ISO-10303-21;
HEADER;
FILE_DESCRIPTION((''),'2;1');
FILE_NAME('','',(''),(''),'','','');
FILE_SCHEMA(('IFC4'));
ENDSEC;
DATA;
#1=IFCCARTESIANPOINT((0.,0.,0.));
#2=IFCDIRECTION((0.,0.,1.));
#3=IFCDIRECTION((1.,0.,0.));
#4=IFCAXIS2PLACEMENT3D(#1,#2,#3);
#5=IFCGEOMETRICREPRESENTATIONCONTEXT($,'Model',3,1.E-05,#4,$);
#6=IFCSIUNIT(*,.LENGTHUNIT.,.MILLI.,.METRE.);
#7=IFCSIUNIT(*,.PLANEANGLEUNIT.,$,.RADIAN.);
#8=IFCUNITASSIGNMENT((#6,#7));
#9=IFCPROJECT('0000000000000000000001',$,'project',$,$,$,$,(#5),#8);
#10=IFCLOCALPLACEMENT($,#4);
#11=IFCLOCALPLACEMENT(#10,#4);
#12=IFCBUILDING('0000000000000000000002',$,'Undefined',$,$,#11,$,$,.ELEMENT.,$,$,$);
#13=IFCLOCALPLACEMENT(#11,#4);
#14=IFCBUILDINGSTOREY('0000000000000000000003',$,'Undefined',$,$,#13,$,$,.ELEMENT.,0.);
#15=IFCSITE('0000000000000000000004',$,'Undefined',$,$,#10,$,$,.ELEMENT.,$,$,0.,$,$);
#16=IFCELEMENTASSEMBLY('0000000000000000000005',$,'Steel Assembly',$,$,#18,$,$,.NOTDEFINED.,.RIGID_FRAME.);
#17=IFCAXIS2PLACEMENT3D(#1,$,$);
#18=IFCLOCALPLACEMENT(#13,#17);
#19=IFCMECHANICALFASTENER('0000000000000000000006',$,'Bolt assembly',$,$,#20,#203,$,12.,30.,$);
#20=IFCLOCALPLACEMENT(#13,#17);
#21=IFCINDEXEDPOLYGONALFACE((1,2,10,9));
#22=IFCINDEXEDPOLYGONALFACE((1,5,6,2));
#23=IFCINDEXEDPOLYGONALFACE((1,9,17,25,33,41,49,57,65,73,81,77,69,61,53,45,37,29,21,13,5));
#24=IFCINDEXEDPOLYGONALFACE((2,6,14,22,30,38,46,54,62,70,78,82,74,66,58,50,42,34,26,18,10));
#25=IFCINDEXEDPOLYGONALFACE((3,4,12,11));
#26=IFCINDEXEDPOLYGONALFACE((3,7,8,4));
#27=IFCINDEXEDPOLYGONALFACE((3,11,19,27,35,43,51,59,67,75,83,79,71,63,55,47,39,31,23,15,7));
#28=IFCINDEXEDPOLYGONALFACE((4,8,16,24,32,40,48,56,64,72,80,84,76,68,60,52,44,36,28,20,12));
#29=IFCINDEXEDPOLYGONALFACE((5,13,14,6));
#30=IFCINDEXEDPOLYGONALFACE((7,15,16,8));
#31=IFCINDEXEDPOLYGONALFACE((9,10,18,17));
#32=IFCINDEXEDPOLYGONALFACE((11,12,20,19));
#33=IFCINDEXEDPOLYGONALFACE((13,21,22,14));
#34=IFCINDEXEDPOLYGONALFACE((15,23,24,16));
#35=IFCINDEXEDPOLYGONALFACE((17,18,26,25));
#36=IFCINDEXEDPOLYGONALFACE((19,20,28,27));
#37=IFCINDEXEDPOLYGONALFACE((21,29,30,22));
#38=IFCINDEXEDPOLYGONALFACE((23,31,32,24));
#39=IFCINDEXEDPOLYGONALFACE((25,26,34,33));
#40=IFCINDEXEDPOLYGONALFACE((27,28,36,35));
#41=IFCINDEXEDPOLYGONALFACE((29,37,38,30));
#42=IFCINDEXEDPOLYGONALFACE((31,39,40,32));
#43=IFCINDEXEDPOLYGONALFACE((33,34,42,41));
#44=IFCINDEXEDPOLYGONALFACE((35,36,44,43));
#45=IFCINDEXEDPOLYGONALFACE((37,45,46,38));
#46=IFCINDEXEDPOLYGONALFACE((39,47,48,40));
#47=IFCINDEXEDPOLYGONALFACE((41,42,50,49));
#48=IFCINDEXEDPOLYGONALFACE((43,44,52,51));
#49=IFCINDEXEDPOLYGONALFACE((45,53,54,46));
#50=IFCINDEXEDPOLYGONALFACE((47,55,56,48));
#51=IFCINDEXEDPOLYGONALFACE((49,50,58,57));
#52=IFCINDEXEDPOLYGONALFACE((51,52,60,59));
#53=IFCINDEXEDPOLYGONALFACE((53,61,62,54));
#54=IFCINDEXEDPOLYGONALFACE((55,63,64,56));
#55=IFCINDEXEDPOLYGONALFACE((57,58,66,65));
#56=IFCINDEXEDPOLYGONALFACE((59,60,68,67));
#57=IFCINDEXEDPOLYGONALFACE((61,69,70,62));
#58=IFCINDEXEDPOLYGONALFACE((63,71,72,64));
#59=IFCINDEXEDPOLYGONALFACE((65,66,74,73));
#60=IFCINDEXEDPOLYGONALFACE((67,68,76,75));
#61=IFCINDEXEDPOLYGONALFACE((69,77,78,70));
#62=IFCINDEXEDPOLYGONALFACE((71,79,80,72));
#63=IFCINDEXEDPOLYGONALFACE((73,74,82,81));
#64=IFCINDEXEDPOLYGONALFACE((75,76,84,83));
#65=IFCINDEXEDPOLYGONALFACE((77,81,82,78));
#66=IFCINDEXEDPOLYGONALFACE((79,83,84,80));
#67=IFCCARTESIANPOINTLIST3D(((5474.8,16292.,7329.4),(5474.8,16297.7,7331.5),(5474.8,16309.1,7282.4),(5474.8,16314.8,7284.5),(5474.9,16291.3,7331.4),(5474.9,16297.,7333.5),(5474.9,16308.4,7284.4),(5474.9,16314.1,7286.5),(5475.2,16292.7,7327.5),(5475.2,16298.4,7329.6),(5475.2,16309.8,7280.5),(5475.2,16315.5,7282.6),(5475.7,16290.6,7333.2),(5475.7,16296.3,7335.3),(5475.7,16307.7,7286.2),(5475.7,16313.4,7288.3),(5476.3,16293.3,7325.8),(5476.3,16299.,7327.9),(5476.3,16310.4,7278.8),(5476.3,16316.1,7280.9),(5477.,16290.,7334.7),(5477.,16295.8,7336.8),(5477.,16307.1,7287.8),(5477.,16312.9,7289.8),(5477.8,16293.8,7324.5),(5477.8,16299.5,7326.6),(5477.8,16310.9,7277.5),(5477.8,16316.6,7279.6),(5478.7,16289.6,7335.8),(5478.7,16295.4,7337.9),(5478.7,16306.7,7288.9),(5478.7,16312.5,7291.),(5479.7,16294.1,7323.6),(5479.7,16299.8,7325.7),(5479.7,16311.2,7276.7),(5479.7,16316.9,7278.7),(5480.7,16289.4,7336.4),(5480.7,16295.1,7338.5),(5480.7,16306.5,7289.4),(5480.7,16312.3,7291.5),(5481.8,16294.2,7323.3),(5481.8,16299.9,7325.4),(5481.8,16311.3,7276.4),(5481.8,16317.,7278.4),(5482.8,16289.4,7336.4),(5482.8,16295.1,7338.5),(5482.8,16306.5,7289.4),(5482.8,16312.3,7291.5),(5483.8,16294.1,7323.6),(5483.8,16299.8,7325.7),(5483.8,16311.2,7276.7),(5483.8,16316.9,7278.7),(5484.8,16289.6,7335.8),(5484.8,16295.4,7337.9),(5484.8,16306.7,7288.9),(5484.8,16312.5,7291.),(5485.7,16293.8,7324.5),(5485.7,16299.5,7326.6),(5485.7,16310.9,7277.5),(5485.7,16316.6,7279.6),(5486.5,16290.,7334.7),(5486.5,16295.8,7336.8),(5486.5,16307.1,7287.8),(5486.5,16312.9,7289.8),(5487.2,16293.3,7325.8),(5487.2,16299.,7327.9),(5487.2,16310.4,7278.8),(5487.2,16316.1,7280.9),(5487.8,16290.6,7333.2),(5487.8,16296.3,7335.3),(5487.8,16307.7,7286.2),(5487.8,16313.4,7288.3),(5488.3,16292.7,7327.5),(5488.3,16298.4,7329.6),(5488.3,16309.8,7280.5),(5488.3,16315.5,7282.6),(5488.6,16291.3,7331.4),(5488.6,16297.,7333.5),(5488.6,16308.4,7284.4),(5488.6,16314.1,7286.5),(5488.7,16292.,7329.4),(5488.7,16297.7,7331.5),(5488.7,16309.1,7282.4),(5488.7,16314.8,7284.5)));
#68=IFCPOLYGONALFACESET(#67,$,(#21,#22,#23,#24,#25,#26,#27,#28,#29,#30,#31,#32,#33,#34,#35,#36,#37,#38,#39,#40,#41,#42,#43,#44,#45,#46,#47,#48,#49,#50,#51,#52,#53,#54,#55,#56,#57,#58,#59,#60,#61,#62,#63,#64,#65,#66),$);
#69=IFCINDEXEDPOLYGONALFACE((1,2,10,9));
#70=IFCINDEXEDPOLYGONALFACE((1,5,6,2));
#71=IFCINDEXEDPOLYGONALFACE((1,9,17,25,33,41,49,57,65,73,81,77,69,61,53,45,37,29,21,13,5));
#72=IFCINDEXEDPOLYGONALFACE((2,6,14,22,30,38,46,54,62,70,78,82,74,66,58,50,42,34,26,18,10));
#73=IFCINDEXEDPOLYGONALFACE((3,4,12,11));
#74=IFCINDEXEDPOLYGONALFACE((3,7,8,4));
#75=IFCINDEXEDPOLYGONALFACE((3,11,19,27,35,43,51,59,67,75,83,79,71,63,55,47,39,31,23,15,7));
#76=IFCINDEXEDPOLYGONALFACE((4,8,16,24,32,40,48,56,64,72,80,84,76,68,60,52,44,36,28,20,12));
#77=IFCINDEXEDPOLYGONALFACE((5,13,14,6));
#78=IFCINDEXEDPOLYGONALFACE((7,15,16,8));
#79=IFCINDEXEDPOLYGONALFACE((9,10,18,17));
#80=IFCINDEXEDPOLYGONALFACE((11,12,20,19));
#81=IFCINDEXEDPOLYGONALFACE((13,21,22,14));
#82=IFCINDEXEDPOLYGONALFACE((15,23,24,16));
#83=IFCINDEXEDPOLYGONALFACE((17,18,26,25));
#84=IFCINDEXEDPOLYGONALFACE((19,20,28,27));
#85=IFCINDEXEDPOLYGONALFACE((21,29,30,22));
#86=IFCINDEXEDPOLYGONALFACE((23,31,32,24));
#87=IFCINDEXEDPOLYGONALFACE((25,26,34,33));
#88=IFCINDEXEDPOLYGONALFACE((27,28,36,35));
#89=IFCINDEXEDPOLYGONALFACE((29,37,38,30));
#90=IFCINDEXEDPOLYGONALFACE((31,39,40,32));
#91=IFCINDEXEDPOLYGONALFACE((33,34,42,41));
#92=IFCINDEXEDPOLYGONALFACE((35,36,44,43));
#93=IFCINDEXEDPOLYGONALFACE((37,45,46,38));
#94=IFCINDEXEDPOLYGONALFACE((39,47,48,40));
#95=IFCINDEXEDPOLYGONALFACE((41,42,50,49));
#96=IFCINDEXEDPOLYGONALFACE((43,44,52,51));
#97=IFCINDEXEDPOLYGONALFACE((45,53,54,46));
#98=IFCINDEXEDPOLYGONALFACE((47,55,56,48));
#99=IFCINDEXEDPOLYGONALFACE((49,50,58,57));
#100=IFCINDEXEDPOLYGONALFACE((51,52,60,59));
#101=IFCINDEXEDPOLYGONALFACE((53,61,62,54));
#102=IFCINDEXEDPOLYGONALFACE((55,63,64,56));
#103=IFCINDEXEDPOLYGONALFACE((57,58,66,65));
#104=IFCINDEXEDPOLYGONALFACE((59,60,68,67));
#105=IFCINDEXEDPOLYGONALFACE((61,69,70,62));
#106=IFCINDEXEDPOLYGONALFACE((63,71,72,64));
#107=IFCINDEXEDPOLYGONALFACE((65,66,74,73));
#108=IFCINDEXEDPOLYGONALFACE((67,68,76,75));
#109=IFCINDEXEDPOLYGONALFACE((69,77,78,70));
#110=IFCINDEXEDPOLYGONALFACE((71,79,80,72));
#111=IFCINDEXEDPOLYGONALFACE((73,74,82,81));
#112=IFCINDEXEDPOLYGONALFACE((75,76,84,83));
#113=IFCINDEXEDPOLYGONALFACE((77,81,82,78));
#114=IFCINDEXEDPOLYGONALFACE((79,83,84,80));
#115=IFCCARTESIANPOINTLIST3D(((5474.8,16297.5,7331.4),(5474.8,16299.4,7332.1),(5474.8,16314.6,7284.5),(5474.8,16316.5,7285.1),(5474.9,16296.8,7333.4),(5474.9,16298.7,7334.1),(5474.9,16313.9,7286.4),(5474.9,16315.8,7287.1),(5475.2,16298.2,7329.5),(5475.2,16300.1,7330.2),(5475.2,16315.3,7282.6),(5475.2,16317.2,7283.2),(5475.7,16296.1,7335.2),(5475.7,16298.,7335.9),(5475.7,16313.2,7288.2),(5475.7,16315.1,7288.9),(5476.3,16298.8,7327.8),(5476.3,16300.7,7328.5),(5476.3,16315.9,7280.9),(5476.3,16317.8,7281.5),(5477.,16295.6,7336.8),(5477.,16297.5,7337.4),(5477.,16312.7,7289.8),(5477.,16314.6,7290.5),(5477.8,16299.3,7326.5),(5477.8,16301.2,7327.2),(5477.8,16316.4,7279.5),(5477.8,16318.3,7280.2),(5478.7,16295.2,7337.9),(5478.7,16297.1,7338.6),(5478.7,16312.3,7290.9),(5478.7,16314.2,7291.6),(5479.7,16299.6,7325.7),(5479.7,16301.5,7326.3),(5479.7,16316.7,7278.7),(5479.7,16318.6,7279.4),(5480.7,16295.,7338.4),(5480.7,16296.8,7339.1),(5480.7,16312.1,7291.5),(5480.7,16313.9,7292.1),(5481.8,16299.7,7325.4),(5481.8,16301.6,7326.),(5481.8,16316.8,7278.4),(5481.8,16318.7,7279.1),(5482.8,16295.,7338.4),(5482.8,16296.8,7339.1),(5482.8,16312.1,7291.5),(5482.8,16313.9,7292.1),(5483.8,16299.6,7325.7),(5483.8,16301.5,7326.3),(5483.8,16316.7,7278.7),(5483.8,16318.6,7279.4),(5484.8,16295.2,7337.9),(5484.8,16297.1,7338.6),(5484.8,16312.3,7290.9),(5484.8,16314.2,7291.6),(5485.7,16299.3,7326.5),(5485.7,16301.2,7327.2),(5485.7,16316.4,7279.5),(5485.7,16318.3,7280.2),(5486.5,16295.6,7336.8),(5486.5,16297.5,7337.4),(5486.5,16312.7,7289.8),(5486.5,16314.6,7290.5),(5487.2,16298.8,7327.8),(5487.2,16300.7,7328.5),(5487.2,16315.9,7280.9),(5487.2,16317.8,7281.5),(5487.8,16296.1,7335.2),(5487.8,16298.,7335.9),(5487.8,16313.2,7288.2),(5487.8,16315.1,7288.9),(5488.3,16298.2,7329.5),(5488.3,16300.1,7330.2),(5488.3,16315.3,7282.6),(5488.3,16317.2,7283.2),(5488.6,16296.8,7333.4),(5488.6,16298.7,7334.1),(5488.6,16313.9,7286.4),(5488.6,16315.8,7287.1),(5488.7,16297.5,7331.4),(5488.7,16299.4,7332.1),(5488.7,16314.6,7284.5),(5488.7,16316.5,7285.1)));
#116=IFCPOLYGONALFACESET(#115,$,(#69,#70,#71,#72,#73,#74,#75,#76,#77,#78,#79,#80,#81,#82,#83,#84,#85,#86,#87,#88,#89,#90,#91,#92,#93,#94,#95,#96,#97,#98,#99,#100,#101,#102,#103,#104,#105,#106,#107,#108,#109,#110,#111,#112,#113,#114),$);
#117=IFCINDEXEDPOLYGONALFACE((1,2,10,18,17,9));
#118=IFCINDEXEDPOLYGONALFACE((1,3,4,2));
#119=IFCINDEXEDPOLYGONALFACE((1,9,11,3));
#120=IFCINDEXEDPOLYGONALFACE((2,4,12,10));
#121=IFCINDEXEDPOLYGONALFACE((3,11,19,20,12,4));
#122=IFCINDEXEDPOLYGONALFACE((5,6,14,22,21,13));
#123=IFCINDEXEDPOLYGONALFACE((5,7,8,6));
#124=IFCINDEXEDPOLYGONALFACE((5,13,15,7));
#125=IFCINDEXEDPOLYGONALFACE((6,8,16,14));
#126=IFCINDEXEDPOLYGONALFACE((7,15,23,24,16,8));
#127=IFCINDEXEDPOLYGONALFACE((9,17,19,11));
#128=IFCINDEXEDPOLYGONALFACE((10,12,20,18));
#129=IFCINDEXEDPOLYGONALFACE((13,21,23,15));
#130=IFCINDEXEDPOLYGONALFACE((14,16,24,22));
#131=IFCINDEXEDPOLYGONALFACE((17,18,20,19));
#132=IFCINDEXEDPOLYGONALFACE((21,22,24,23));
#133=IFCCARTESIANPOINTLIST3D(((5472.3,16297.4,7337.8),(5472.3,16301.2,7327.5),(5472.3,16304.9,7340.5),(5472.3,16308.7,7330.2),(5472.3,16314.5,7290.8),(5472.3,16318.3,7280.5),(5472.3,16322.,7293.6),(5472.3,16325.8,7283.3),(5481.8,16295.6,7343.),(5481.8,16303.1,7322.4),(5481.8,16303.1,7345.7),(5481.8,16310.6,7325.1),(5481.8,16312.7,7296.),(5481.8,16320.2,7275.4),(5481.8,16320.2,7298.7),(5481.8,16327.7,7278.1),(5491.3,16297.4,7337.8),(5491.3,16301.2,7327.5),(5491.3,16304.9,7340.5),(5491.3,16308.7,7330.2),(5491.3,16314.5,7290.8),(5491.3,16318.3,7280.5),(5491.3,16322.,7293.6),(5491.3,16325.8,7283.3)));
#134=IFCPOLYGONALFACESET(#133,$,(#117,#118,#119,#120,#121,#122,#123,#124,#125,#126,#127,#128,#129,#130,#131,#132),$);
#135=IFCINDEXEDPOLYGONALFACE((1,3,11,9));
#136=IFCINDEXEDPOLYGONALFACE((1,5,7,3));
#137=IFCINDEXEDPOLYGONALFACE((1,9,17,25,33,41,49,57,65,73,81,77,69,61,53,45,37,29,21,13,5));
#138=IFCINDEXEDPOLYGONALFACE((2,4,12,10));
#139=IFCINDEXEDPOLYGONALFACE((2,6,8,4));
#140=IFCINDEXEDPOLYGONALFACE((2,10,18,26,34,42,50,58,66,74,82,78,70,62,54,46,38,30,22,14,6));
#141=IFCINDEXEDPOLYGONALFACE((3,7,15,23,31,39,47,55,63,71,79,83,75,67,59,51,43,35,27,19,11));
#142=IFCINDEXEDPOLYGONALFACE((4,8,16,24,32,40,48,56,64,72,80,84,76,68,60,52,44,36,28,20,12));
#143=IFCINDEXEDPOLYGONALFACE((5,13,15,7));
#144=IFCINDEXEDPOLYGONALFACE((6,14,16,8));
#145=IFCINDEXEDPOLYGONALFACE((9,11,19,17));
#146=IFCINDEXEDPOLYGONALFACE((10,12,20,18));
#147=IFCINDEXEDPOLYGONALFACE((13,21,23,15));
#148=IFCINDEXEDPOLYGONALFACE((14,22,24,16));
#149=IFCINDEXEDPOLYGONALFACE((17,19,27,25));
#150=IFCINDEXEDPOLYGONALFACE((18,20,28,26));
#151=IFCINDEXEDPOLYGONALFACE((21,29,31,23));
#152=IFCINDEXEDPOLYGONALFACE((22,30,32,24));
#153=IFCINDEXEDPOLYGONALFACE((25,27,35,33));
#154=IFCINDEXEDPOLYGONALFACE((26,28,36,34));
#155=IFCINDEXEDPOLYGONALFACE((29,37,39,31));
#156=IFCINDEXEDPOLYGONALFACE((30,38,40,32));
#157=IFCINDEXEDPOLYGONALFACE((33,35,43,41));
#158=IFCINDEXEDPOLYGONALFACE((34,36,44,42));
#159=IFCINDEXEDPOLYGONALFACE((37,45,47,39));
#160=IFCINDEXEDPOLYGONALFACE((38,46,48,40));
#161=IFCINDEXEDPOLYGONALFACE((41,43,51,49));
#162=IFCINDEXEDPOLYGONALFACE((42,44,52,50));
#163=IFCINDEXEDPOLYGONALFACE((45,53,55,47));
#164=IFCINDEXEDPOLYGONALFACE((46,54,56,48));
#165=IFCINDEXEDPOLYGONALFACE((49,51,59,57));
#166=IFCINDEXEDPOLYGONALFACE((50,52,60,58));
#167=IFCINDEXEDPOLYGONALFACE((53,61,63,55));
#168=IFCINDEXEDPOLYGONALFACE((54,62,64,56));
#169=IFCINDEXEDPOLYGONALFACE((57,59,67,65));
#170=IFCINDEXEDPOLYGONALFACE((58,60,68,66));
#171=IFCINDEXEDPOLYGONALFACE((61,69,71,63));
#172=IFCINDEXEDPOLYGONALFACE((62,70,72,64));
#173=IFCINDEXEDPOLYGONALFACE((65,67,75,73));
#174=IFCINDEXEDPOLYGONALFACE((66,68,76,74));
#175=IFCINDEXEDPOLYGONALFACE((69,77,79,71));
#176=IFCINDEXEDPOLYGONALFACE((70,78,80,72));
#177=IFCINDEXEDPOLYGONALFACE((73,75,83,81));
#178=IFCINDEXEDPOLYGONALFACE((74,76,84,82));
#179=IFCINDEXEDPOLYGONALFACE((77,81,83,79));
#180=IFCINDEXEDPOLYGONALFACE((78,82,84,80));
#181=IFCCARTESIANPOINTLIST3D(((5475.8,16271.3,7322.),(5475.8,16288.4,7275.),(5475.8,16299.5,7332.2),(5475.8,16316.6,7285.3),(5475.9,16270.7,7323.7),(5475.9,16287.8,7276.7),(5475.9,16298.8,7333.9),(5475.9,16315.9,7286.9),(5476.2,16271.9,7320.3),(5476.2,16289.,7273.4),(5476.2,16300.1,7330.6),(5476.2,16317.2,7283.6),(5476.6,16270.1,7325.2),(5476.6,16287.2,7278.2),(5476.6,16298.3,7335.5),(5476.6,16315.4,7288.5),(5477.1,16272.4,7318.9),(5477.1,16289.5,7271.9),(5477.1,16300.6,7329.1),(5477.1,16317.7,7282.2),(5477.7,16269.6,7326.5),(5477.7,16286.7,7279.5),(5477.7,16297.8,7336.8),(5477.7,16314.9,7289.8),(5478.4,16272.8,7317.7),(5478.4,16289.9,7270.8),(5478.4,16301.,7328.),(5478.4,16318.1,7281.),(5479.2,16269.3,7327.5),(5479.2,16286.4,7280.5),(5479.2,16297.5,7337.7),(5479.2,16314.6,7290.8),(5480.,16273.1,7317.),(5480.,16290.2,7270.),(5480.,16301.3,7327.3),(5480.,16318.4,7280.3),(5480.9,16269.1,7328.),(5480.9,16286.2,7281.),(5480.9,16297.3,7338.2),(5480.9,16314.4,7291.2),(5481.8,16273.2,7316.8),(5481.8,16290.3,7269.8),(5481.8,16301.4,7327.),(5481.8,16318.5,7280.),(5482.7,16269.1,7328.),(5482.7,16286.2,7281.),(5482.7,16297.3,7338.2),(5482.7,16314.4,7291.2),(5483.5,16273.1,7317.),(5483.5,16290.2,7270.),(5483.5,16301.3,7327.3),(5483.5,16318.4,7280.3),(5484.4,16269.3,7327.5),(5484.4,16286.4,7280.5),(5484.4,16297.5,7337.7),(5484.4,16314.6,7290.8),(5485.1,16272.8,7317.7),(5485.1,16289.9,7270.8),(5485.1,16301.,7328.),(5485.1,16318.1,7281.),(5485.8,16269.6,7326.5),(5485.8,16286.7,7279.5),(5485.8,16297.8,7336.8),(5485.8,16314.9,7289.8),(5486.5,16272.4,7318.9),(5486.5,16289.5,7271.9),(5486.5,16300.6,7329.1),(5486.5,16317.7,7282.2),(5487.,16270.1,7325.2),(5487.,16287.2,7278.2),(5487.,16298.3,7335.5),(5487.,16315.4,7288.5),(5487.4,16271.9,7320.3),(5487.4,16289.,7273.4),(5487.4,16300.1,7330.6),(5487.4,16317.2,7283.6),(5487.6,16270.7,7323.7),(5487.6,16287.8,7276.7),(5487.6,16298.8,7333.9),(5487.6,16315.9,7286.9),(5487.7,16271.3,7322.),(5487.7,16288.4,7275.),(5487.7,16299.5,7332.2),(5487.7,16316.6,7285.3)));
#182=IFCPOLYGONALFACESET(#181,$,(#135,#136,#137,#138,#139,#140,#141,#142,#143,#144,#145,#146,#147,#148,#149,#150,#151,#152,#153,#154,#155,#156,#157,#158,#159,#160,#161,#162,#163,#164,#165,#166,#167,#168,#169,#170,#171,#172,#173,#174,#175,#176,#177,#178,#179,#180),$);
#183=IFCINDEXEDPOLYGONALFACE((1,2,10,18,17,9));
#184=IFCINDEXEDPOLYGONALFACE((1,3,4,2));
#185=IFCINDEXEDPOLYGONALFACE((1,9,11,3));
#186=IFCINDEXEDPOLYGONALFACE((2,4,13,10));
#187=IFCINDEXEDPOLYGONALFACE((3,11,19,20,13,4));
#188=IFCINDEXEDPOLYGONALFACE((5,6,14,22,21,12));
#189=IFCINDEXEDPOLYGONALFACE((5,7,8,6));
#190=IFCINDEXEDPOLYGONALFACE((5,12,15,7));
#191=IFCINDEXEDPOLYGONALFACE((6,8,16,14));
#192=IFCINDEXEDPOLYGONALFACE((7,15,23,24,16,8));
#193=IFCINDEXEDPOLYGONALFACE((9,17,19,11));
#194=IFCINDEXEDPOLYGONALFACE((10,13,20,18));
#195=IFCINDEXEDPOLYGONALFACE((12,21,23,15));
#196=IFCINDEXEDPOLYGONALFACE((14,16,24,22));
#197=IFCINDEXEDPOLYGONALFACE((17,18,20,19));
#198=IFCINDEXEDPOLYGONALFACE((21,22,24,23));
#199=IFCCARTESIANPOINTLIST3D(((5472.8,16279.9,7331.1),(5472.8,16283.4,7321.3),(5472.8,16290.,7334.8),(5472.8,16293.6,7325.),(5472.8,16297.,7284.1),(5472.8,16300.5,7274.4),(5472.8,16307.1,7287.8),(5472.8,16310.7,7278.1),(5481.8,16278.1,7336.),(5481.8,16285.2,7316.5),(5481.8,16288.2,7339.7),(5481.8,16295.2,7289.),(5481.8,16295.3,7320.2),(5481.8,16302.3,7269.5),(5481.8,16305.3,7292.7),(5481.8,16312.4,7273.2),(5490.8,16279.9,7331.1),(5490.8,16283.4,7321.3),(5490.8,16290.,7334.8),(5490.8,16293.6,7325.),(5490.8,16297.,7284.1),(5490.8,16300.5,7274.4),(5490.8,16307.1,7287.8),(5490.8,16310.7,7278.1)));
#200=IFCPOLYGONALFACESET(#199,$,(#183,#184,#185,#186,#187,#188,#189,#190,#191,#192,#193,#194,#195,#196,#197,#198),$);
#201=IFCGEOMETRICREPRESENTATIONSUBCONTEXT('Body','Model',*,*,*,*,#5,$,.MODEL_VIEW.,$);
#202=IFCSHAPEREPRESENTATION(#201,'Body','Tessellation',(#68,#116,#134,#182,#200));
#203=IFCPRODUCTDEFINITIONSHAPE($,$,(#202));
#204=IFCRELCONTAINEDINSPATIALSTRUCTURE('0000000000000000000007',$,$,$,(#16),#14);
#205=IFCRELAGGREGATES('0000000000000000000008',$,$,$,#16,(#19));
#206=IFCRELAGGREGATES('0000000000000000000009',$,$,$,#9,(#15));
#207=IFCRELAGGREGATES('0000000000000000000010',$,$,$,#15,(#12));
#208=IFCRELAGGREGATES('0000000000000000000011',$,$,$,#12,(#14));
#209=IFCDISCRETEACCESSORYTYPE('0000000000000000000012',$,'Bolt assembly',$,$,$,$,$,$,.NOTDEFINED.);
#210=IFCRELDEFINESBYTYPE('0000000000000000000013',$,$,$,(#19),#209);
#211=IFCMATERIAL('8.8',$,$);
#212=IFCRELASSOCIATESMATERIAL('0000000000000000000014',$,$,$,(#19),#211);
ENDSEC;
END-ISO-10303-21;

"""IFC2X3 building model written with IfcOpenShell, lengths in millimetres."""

from ifc_helpers import new_model, si_unit, frame, origin_with_axes, origin_2d_with_axis, place, context, subcontext, project, spatial, polyline, circle, outline, extrude, source, transform, mapped, material, type_object, element, aggregate, save


model = new_model("IFC2X3")

# Units and contexts
model_context = context("Model", 3, precision=1e-05, world=origin_with_axes())
body_context = subcontext(model_context, "Body", "Model", "MODEL_VIEW")
ifc_project = project(units=[si_unit("LENGTHUNIT", "METRE", prefix="MILLI"), si_unit("PLANEANGLEUNIT", "RADIAN")], contexts=[model_context])

# Site, building, storey
site_placement = place(None, origin_with_axes())
site = spatial("IfcSite", under=ifc_project, at=site_placement, Name="Undefined", CompositionType="ELEMENT", RefElevation=0.0)
building_placement = place(site_placement, origin_with_axes())
building = spatial("IfcBuilding", under=site, at=building_placement, Name="Undefined", CompositionType="ELEMENT")
storey_placement = place(building_placement, origin_with_axes())
storey = spatial("IfcBuildingStorey", under=building, at=storey_placement, Name="Undefined", CompositionType="ELEMENT", Elevation=0.0)

# Element assembly
assembly_1_placement = place(storey_placement, origin_with_axes())
assembly_1 = element("IfcElementAssembly", 1, at=assembly_1_placement, inside=storey, Name="Steel Assembly", AssemblyPlace="NOTDEFINED", PredefinedType="RIGID_FRAME")
ifc_material_1 = material(Name="8.8")
discrete_accessory_type_1 = type_object("IfcDiscreteAccessoryType", Name="Bolt assembly")

# Shared definitions
shared_shape_1 = source(origin_with_axes(), body_context, "Body", "SweptSolid", [
    extrude(circle(Radius=7.0, at=origin_2d_with_axis()), frame((0.0, -6.1, 0.0), z_axis=(0.0, 1.0, 0.0), x_axis=(1.0, 0.0, 0.0)), (0.0, 0.0, 1.0), 6.1),
    extrude(circle(Radius=7.0, at=origin_2d_with_axis()), frame((0.0, -7.9, 0.0), z_axis=(0.0, 1.0, 0.0), x_axis=(1.0, 0.0, 0.0)), (0.0, 0.0, 1.0), 2.0),
    extrude(outline(polyline([(11.0, 0.0), (5.5, 9.5), (-5.5, 9.5), (-11.0, 0.0), (-5.5, -9.5), (5.5, -9.5), (11.0, 0.0)])), frame((0.0, -16.0, 0.0), z_axis=(0.0, 1.0, 0.0), x_axis=(1.0, 0.0, 0.0)), (0.0, 0.0, 1.0), 8.0),
    extrude(circle(Radius=6.0, at=origin_2d_with_axis()), frame((0.0, -8.0, 0.0), z_axis=(0.0, 1.0, 0.0), x_axis=(1.0, 0.0, 0.0)), (0.0, 0.0, 1.0), 30.0),
    extrude(outline(polyline([(10.4, 0.0), (5.2, 9.0), (-5.2, 9.0), (-10.4, 0.0), (-5.2, -9.0), (5.2, -9.0), (10.4, 0.0)])), frame((0.0, 0.0, 0.0), z_axis=(0.0, 1.0, 0.0), x_axis=(1.0, 0.0, 0.0)), (0.0, 0.0, 1.0), 10.8),
])

# Mechanical fastener
mechanical_fastener_1_placement = place(assembly_1_placement, frame((5481.8, 16291.8, 7329.9), z_axis=(-1.0, 0.0, 0.0), x_axis=(0.0, 0.34202, -0.939693)))
mechanical_fastener_1 = element("IfcMechanicalFastener", 2, at=mechanical_fastener_1_placement, type_object=discrete_accessory_type_1, material=ifc_material_1, Name="Bolt assembly", NominalDiameter=12.0, NominalLength=30.0, context=body_context, shape_type="MappedRepresentation", body=[
    mapped(shared_shape_1, transform((0.0, 0.0, 0.0))),
    mapped(shared_shape_1, transform((50.0, 0.0, 0.0))),
])
aggregate(assembly_1, [mechanical_fastener_1])

save(model, "model.ifc")
